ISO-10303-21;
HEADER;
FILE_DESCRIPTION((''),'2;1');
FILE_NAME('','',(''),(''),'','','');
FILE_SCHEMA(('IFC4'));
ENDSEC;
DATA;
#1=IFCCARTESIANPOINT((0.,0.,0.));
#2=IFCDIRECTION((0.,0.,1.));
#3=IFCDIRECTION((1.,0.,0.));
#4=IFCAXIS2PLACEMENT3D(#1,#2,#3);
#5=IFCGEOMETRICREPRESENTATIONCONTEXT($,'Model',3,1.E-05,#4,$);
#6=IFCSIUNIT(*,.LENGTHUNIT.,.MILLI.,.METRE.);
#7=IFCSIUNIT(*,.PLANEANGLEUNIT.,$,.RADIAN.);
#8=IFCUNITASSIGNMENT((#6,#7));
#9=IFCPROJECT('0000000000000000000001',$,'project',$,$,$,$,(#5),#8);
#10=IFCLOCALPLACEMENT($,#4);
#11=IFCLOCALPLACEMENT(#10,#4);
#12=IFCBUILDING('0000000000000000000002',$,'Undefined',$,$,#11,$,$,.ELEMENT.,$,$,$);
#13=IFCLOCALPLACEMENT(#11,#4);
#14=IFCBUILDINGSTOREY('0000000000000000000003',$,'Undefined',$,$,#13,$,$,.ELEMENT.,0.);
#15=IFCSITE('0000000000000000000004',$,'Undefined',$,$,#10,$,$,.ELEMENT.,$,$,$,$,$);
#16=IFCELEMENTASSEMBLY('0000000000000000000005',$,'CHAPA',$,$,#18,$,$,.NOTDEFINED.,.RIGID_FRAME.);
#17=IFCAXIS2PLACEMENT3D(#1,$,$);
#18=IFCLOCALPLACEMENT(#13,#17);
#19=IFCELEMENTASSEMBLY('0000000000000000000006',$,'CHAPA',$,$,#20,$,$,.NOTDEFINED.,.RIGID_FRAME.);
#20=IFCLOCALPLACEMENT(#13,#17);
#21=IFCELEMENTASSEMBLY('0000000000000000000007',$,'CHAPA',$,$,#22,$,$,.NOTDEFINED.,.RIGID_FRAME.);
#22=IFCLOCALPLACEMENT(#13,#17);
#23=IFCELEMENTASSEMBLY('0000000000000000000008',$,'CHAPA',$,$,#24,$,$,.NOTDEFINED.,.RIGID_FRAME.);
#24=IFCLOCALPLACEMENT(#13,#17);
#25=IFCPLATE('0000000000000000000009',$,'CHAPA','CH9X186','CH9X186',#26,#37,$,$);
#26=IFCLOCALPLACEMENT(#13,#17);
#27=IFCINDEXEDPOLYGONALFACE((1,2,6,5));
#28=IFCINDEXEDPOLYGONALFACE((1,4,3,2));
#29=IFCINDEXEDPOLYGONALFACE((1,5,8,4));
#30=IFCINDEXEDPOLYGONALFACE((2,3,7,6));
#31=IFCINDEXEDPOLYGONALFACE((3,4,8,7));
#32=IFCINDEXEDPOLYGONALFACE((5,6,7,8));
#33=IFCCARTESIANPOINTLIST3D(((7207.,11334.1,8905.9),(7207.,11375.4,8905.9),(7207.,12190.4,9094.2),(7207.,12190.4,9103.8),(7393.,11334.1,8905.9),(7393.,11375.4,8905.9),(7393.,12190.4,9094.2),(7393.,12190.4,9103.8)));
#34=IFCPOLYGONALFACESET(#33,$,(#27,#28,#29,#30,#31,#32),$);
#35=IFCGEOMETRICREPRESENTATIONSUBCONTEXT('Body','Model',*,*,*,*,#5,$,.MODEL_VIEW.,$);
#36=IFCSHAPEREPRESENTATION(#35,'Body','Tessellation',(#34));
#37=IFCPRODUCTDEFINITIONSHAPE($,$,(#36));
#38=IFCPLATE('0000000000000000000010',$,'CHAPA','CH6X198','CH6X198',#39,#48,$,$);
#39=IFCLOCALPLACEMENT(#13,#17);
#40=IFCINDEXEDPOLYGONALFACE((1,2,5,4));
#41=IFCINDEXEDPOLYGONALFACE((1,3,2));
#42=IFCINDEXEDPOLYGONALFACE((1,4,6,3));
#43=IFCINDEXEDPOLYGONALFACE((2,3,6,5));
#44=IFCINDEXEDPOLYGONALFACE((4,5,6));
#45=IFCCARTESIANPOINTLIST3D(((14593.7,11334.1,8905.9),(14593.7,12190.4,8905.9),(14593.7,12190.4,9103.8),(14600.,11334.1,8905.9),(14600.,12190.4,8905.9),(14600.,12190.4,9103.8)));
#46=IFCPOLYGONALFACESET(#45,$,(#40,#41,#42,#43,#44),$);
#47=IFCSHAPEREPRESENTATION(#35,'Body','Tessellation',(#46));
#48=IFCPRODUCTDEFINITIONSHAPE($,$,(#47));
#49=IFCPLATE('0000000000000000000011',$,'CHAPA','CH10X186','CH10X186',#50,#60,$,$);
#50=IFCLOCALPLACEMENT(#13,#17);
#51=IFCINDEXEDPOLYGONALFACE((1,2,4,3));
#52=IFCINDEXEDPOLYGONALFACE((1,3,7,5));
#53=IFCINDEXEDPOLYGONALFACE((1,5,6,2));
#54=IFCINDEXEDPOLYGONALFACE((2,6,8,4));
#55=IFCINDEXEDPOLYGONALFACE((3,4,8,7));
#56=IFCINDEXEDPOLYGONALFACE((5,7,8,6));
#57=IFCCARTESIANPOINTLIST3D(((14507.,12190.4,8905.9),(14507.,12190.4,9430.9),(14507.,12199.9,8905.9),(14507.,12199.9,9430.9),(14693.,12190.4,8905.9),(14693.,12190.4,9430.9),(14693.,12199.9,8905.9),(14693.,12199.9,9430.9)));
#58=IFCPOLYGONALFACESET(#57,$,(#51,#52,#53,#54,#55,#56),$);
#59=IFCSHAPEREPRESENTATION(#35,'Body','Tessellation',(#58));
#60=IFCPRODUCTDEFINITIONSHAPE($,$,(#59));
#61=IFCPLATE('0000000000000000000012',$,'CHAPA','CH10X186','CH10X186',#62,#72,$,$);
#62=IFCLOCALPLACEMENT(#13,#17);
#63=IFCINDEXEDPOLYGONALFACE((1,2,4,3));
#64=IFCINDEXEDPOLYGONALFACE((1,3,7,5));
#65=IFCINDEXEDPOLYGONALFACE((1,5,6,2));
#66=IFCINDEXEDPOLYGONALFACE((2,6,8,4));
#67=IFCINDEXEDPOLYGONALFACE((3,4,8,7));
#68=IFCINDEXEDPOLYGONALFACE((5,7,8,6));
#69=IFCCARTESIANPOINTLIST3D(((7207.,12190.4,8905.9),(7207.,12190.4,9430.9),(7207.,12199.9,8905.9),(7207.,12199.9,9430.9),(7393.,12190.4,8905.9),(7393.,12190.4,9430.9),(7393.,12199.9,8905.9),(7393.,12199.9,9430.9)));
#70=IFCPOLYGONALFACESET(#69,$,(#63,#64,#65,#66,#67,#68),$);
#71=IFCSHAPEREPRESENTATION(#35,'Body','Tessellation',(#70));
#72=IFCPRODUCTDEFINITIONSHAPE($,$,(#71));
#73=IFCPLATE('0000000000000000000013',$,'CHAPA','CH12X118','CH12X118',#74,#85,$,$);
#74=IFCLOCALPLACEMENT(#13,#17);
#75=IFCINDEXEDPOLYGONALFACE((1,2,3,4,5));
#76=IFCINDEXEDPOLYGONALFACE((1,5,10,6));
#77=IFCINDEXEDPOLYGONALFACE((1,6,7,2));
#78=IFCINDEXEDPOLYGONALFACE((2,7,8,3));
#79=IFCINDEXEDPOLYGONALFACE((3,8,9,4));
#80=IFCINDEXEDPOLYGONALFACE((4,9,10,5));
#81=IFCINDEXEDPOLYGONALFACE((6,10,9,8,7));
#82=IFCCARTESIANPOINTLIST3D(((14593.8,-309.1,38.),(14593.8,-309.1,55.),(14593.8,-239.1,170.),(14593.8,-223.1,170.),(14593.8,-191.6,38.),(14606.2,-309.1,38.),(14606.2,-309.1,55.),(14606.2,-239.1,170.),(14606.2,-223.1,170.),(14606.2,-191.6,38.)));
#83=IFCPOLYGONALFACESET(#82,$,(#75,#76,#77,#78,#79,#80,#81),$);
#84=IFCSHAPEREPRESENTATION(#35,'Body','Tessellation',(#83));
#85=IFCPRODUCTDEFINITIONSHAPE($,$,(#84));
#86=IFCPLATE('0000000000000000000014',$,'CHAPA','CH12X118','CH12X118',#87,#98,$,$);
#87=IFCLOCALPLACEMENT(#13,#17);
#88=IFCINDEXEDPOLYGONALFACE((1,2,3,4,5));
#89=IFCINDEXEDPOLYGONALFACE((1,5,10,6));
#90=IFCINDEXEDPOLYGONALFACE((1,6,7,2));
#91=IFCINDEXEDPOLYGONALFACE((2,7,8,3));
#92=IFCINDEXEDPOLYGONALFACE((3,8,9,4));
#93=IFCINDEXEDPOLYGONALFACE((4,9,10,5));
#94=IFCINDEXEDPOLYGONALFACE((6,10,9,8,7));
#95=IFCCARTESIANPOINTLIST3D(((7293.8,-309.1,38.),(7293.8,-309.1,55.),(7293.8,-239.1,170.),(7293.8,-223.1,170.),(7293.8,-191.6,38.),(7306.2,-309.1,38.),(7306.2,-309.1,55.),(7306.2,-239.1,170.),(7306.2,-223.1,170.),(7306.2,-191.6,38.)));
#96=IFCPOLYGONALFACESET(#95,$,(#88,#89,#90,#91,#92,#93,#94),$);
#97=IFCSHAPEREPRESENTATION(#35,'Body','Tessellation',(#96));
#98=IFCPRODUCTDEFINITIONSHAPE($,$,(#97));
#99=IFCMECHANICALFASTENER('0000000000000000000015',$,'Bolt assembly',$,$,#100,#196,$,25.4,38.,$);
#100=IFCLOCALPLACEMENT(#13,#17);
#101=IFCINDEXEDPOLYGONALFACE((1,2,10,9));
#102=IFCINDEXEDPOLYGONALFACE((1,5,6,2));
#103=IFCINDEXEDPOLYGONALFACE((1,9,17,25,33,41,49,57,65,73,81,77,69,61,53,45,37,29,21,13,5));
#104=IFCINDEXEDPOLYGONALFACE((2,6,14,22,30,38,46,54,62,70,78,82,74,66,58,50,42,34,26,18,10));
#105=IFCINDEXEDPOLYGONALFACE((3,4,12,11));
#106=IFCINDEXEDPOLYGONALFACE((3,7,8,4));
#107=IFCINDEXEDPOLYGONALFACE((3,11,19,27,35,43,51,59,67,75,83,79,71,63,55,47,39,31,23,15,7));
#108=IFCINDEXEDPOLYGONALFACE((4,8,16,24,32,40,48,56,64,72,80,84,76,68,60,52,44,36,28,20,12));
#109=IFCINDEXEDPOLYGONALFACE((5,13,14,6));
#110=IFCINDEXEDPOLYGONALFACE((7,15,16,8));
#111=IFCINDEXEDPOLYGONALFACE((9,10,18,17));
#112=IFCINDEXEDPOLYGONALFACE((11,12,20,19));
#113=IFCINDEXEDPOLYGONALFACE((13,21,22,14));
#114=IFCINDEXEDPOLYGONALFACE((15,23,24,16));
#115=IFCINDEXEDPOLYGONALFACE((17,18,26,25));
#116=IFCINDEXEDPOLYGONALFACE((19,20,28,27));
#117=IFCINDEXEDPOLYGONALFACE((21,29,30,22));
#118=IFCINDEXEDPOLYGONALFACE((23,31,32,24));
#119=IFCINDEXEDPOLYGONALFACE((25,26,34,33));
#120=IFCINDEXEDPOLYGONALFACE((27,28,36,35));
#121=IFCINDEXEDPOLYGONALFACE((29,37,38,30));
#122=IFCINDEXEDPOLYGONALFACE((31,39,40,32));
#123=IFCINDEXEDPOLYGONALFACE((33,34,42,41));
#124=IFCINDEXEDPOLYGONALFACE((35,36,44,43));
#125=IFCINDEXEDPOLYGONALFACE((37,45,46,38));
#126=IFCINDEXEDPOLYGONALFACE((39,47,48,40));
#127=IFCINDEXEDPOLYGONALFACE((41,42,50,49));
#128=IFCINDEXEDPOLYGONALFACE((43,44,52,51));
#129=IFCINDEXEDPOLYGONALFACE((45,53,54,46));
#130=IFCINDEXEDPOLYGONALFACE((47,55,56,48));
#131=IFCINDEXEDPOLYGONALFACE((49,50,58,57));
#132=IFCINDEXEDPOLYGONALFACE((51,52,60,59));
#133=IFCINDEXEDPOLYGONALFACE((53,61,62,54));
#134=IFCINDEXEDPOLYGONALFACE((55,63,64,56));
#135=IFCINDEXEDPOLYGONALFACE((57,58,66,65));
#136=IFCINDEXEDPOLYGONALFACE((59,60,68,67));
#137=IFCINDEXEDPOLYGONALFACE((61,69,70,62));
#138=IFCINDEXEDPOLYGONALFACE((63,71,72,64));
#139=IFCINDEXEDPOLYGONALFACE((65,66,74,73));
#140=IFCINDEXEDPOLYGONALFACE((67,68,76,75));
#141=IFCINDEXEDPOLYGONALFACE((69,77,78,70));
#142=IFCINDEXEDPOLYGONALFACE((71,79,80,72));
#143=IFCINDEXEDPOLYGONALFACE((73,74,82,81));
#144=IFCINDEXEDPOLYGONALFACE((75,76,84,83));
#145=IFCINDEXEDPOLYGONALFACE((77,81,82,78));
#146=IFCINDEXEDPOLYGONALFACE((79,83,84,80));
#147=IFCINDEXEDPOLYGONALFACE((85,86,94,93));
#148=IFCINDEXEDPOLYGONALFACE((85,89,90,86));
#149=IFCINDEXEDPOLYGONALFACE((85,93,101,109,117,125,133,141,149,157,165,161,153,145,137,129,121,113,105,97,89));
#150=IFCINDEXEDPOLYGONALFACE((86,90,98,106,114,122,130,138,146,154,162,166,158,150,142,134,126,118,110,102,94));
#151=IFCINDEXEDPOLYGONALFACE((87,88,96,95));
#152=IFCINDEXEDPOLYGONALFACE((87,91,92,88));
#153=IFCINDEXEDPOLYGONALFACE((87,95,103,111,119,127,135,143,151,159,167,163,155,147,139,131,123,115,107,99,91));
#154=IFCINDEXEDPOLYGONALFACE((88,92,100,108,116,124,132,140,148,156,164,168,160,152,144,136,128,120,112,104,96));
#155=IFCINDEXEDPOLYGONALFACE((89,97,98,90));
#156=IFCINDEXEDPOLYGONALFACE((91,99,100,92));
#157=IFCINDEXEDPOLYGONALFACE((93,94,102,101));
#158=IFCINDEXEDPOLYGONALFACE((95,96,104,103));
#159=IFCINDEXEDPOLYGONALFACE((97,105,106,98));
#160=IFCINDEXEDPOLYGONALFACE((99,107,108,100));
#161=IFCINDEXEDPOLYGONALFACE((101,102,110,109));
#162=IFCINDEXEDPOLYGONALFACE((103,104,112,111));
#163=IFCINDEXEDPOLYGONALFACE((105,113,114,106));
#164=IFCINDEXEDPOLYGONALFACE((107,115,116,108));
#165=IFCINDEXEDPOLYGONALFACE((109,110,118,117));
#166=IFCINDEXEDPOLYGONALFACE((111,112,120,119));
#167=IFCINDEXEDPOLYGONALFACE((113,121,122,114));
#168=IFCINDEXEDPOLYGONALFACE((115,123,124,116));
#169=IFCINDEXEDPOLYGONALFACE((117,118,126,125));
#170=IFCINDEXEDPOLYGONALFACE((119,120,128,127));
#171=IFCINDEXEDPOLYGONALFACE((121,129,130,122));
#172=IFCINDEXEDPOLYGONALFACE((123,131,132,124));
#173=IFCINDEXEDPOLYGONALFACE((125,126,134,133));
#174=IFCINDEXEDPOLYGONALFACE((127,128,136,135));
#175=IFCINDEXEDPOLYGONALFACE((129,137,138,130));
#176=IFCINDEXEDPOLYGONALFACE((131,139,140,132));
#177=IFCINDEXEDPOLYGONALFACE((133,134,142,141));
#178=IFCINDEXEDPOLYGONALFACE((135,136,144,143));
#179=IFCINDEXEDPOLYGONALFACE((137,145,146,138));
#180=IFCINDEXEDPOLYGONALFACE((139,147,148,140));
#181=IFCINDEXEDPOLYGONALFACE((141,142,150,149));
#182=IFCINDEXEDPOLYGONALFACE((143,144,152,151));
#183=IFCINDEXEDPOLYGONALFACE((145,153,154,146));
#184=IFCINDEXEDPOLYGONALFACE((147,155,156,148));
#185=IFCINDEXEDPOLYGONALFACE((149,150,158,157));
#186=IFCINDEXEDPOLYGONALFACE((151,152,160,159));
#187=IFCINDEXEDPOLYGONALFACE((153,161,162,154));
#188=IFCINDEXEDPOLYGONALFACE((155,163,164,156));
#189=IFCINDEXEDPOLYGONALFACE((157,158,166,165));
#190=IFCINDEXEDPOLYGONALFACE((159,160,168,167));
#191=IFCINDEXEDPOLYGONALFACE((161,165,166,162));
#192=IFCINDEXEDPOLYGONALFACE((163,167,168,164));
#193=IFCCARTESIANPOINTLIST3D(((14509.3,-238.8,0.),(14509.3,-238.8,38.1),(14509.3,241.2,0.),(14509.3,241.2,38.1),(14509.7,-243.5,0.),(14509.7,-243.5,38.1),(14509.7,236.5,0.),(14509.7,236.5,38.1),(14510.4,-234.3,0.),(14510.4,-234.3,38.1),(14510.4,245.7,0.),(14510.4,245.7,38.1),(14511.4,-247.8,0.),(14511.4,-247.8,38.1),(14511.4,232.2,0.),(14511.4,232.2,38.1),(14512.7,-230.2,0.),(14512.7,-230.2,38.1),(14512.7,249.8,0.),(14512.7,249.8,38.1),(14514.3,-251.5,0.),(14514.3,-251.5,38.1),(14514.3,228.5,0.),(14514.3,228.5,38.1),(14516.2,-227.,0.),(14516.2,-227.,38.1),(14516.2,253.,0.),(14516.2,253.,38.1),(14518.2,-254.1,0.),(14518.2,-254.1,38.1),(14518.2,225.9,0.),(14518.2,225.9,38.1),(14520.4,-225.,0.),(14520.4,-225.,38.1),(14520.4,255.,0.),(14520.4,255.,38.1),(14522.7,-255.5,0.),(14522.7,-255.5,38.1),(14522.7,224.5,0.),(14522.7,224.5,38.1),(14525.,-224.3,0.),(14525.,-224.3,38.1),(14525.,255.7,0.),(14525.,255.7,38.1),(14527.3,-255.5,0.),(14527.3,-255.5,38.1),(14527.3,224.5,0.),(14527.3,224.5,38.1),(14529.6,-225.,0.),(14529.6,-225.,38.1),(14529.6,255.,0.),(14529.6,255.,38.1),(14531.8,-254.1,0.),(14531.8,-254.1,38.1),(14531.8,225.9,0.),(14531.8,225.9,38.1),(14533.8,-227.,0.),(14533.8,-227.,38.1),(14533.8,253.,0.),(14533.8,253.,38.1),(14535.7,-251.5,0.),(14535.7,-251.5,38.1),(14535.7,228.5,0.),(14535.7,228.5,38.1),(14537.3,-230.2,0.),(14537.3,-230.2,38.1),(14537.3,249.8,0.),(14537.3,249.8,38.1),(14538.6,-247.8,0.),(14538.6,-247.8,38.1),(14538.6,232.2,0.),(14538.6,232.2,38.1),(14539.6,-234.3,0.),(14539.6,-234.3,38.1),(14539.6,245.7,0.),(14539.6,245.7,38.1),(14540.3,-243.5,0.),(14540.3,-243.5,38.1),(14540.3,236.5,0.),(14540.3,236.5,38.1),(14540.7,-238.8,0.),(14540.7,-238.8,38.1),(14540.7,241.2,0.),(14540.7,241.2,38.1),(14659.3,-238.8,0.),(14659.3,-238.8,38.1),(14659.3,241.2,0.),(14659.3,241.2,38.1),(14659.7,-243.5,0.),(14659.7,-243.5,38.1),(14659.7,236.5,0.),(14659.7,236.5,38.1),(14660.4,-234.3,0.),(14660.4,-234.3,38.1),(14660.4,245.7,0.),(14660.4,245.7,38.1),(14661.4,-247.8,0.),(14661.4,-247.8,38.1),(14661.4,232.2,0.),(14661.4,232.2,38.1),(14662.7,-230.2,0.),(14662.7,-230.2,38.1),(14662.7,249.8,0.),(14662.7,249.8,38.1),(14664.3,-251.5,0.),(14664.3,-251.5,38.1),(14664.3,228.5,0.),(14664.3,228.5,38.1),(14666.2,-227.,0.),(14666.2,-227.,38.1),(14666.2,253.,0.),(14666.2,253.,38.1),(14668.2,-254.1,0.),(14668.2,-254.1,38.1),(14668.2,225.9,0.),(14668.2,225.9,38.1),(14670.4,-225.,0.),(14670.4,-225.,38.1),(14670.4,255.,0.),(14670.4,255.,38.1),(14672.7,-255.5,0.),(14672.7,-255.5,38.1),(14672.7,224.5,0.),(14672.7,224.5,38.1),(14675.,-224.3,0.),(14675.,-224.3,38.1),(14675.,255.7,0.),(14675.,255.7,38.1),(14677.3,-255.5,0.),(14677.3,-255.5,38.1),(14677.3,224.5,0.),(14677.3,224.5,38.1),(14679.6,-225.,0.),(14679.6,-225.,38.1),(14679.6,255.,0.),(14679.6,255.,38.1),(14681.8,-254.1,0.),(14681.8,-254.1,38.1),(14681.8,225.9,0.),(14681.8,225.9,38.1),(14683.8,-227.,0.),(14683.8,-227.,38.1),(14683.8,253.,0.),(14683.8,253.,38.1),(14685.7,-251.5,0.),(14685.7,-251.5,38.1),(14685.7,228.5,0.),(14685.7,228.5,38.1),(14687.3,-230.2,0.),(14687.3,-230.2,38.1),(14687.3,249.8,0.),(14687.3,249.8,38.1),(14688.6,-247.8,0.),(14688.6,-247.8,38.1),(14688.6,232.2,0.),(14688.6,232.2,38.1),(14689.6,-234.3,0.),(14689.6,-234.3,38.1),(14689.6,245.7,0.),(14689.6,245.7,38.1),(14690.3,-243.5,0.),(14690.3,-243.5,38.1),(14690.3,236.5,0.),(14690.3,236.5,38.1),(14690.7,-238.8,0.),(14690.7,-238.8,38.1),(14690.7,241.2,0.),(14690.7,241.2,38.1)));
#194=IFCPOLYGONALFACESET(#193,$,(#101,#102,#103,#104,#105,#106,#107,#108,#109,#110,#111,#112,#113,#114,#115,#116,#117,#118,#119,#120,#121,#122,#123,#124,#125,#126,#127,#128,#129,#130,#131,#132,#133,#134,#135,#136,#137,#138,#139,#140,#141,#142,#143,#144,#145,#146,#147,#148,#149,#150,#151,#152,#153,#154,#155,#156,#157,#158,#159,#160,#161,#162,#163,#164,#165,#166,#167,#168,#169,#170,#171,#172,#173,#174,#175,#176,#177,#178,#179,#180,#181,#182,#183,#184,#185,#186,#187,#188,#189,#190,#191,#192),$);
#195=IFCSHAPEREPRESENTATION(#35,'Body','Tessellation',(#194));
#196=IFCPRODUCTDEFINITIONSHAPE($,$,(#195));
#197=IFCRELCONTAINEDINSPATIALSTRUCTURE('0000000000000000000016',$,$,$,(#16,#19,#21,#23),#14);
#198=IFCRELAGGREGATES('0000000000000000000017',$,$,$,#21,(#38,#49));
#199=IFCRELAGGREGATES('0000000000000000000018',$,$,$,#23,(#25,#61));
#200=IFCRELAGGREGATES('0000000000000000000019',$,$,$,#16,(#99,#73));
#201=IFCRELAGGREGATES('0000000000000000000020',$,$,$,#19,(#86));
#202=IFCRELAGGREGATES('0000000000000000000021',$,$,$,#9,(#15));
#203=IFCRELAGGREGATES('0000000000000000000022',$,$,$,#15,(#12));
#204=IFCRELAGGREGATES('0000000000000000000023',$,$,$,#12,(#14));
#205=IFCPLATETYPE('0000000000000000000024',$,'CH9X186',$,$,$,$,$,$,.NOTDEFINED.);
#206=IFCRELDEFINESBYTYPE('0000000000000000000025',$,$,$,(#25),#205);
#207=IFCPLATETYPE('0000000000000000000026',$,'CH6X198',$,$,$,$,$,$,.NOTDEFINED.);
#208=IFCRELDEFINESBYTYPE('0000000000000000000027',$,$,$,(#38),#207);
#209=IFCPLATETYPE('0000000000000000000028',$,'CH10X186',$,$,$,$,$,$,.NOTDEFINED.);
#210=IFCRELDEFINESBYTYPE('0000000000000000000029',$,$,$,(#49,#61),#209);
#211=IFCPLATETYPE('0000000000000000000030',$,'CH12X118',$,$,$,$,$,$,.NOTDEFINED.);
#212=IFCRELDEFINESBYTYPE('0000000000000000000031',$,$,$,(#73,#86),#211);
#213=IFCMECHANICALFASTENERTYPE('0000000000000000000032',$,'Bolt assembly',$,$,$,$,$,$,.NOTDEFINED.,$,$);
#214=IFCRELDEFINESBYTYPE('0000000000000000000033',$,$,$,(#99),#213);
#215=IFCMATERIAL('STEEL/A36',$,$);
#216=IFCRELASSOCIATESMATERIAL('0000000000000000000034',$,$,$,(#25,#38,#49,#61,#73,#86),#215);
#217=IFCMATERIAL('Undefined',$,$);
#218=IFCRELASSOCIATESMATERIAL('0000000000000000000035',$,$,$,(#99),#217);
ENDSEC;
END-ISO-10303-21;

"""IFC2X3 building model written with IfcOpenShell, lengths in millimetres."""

from ifc_helpers import new_model, si_unit, frame, origin_with_axes, origin_2d_with_axis, place, context, subcontext, project, spatial, polyline, circle, outline, extrude, clip, halfspace, source, transform, mapped, material, type_object, element, aggregate, save


model = new_model("IFC2X3")

# Units and contexts
model_context = context("Model", 3, precision=1e-05, world=origin_with_axes())
body_context = subcontext(model_context, "Body", "Model", "MODEL_VIEW")
ifc_project = project(units=[si_unit("LENGTHUNIT", "METRE", prefix="MILLI"), si_unit("PLANEANGLEUNIT", "RADIAN")], contexts=[model_context])

# Site, building, storey
site_placement = place(None, origin_with_axes())
site = spatial("IfcSite", under=ifc_project, at=site_placement, Name="Undefined", CompositionType="ELEMENT")
building_placement = place(site_placement, origin_with_axes())
building = spatial("IfcBuilding", under=site, at=building_placement, Name="Undefined", CompositionType="ELEMENT")
storey_placement = place(building_placement, origin_with_axes())
storey = spatial("IfcBuildingStorey", under=building, at=storey_placement, Name="Undefined", CompositionType="ELEMENT", Elevation=0.0)

# Element assemblies
assembly_1_placement = place(storey_placement, origin_with_axes())
assembly_1 = element("IfcElementAssembly", 1, at=assembly_1_placement, inside=storey, Name="CHAPA", AssemblyPlace="NOTDEFINED", PredefinedType="RIGID_FRAME")
assembly_2_placement = place(storey_placement, origin_with_axes())
assembly_2 = element("IfcElementAssembly", 2, at=assembly_2_placement, inside=storey, Name="CHAPA", AssemblyPlace="NOTDEFINED", PredefinedType="RIGID_FRAME")

# Shared definitions
ifc_material_1 = material(Name="STEEL/A36")

# Element assemblies, plate
assembly_3_placement = place(storey_placement, origin_with_axes())
assembly_3 = element("IfcElementAssembly", 3, at=assembly_3_placement, inside=storey, Name="CHAPA", AssemblyPlace="NOTDEFINED", PredefinedType="RIGID_FRAME")
plate_type_1 = type_object("IfcPlateType", Name="CH9X186", PredefinedType="NOTDEFINED")
assembly_4_placement = place(storey_placement, origin_with_axes())
assembly_4 = element("IfcElementAssembly", 4, at=assembly_4_placement, inside=storey, Name="CHAPA", AssemblyPlace="NOTDEFINED", PredefinedType="RIGID_FRAME")
plate_1_placement = place(assembly_4_placement, frame((7393.0, 12191.4, 9099.3), z_axis=(0.0, -0.225125, 0.97433), x_axis=(-1.0, 0.0, 0.0)))
plate_1 = element("IfcPlate", 5, at=plate_1_placement, type_object=plate_type_1, material=ifc_material_1, Name="CHAPA", Description="CH9X186", ObjectType="CH9X186", context=body_context, shape_type="Clipping", body=[
    clip(clip(extrude(outline(polyline([(0.0, 0.0), (186.0, 0.0), (186.0, 878.9), (0.0, 878.9), (0.0, 0.0)])), frame((0.0, 0.0, -4.7), z_axis=(0.0, 0.0, 1.0), x_axis=(1.0, 0.0, 0.0)), (0.0, 0.0, 1.0), 9.3), halfspace(frame((186.0, -500.0, -314.0), z_axis=(0.0, 0.225128, -0.974329), x_axis=(0.0, 0.974329, 0.225128)), False)), halfspace(frame((0.0, 2.1, -4.6), z_axis=(0.0, -0.97433, -0.225125), x_axis=(0.0, -0.225125, 0.97433)), False)),
])

# Plates
plate_type_2 = type_object("IfcPlateType", Name="CH6X198", PredefinedType="NOTDEFINED")
plate_2_placement = place(assembly_3_placement, frame((14596.9, 11334.1, 8905.9), z_axis=(1.0, 0.0, 0.0), x_axis=(0.0, 1.0, 0.0)))
plate_2 = element("IfcPlate", 6, at=plate_2_placement, type_object=plate_type_2, material=ifc_material_1, Name="CHAPA", Description="CH6X198", ObjectType="CH6X198", context=body_context, shape_type="SweptSolid", body=[
    extrude(outline(polyline([(0.0, 0.0), (856.3, 0.0), (856.3, 197.9), (0.0, 0.0)])), frame((0.0, 0.0, -3.1), z_axis=(0.0, 0.0, 1.0), x_axis=(1.0, 0.0, 0.0)), (0.0, 0.0, 1.0), 6.3),
])
plate_type_3 = type_object("IfcPlateType", Name="CH10X186", PredefinedType="NOTDEFINED")
plate_3_placement = place(assembly_3_placement, frame((14693.0, 12195.2, 9430.9), z_axis=(0.0, -1.0, 0.0), x_axis=(-1.0, 0.0, 0.0)))
plate_3 = element("IfcPlate", 7, at=plate_3_placement, type_object=plate_type_3, material=ifc_material_1, Name="CHAPA", Description="CH10X186", ObjectType="CH10X186", context=body_context, shape_type="SweptSolid", body=[
    extrude(outline(polyline([(0.0, 0.0), (186.0, 0.0), (186.0, 525.0), (0.0, 525.0), (0.0, 0.0)])), frame((0.0, 0.0, -4.8), z_axis=(0.0, 0.0, 1.0), x_axis=(1.0, 0.0, 0.0)), (0.0, 0.0, 1.0), 9.5),
])
aggregate(assembly_3, [plate_2, plate_3])
plate_4_placement = place(assembly_4_placement, frame((7393.0, 12195.2, 9430.9), z_axis=(0.0, -1.0, 0.0), x_axis=(-1.0, 0.0, 0.0)))
plate_4 = element("IfcPlate", 8, at=plate_4_placement, type_object=plate_type_3, material=ifc_material_1, Name="CHAPA", Description="CH10X186", ObjectType="CH10X186", context=body_context, shape_type="SweptSolid", body=[
    extrude(outline(polyline([(0.0, 0.0), (186.0, 0.0), (186.0, 525.0), (0.0, 525.0), (0.0, 0.0)])), frame((0.0, 0.0, -4.8), z_axis=(0.0, 0.0, 1.0), x_axis=(1.0, 0.0, 0.0)), (0.0, 0.0, 1.0), 9.5),
])
aggregate(assembly_4, [plate_1, plate_4])
plate_type_4 = type_object("IfcPlateType", Name="CH12X118", PredefinedType="NOTDEFINED")
plate_5_placement = place(assembly_1_placement, frame((14600.0, -309.1, 38.0), z_axis=(1.0, 0.0, 0.0), x_axis=(0.0, 1.0, 0.0)))
plate_5 = element("IfcPlate", 9, at=plate_5_placement, type_object=plate_type_4, material=ifc_material_1, Name="CHAPA", Description="CH12X118", ObjectType="CH12X118", context=body_context, shape_type="SweptSolid", body=[
    extrude(outline(polyline([(0.0, 0.0), (117.5, 0.0), (85.9, 132.0), (70.0, 132.0), (0.0, 17.0), (0.0, 0.0)])), frame((0.0, 0.0, -6.2), z_axis=(0.0, 0.0, 1.0), x_axis=(1.0, 0.0, 0.0)), (0.0, 0.0, 1.0), 12.5),
])
plate_6_placement = place(assembly_2_placement, frame((7300.0, -309.1, 38.0), z_axis=(1.0, 0.0, 0.0), x_axis=(0.0, 1.0, 0.0)))
plate_6 = element("IfcPlate", 10, at=plate_6_placement, type_object=plate_type_4, material=ifc_material_1, Name="CHAPA", Description="CH12X118", ObjectType="CH12X118", context=body_context, shape_type="SweptSolid", body=[
    extrude(outline(polyline([(0.0, 0.0), (117.5, 0.0), (85.9, 132.0), (70.0, 132.0), (0.0, 17.0), (0.0, 0.0)])), frame((0.0, 0.0, -6.2), z_axis=(0.0, 0.0, 1.0), x_axis=(1.0, 0.0, 0.0)), (0.0, 0.0, 1.0), 12.5),
])

# Shared definitions
ifc_material_2 = material(Name="Undefined")
mechanical_fastener_type = type_object("IfcMechanicalFastenerType", Name="Bolt assembly")

# Mechanical fastener
shared_shape_1 = source(origin_with_axes(), body_context, "Body", "SweptSolid", [
    extrude(circle(Radius=15.7, at=origin_2d_with_axis()), frame((0.0, -38.0, 0.0), z_axis=(0.0, 1.0, 0.0), x_axis=(1.0, 0.0, 0.0)), (0.0, 0.0, 1.0), 38.1),
])
mechanical_fastener_1_placement = place(assembly_1_placement, frame((14600.0, -240.0, 38.0), z_axis=(1.0, 0.0, 0.0), x_axis=(0.0, 1.0, 0.0)))
mechanical_fastener_1 = element("IfcMechanicalFastener", 11, at=mechanical_fastener_1_placement, type_object=mechanical_fastener_type, material=ifc_material_2, Name="Bolt assembly", NominalDiameter=25.4, NominalLength=38.0, context=body_context, shape_type="MappedRepresentation", body=[
    mapped(shared_shape_1, transform((0.0, 0.0, -75.0))),
    mapped(shared_shape_1, transform((0.0, 0.0, 75.0))),
    mapped(shared_shape_1, transform((480.0, 0.0, -75.0))),
    mapped(shared_shape_1, transform((480.0, 0.0, 75.0))),
])
aggregate(assembly_1, [mechanical_fastener_1, plate_5])
aggregate(assembly_2, [plate_6])

save(model, "model.ifc")
